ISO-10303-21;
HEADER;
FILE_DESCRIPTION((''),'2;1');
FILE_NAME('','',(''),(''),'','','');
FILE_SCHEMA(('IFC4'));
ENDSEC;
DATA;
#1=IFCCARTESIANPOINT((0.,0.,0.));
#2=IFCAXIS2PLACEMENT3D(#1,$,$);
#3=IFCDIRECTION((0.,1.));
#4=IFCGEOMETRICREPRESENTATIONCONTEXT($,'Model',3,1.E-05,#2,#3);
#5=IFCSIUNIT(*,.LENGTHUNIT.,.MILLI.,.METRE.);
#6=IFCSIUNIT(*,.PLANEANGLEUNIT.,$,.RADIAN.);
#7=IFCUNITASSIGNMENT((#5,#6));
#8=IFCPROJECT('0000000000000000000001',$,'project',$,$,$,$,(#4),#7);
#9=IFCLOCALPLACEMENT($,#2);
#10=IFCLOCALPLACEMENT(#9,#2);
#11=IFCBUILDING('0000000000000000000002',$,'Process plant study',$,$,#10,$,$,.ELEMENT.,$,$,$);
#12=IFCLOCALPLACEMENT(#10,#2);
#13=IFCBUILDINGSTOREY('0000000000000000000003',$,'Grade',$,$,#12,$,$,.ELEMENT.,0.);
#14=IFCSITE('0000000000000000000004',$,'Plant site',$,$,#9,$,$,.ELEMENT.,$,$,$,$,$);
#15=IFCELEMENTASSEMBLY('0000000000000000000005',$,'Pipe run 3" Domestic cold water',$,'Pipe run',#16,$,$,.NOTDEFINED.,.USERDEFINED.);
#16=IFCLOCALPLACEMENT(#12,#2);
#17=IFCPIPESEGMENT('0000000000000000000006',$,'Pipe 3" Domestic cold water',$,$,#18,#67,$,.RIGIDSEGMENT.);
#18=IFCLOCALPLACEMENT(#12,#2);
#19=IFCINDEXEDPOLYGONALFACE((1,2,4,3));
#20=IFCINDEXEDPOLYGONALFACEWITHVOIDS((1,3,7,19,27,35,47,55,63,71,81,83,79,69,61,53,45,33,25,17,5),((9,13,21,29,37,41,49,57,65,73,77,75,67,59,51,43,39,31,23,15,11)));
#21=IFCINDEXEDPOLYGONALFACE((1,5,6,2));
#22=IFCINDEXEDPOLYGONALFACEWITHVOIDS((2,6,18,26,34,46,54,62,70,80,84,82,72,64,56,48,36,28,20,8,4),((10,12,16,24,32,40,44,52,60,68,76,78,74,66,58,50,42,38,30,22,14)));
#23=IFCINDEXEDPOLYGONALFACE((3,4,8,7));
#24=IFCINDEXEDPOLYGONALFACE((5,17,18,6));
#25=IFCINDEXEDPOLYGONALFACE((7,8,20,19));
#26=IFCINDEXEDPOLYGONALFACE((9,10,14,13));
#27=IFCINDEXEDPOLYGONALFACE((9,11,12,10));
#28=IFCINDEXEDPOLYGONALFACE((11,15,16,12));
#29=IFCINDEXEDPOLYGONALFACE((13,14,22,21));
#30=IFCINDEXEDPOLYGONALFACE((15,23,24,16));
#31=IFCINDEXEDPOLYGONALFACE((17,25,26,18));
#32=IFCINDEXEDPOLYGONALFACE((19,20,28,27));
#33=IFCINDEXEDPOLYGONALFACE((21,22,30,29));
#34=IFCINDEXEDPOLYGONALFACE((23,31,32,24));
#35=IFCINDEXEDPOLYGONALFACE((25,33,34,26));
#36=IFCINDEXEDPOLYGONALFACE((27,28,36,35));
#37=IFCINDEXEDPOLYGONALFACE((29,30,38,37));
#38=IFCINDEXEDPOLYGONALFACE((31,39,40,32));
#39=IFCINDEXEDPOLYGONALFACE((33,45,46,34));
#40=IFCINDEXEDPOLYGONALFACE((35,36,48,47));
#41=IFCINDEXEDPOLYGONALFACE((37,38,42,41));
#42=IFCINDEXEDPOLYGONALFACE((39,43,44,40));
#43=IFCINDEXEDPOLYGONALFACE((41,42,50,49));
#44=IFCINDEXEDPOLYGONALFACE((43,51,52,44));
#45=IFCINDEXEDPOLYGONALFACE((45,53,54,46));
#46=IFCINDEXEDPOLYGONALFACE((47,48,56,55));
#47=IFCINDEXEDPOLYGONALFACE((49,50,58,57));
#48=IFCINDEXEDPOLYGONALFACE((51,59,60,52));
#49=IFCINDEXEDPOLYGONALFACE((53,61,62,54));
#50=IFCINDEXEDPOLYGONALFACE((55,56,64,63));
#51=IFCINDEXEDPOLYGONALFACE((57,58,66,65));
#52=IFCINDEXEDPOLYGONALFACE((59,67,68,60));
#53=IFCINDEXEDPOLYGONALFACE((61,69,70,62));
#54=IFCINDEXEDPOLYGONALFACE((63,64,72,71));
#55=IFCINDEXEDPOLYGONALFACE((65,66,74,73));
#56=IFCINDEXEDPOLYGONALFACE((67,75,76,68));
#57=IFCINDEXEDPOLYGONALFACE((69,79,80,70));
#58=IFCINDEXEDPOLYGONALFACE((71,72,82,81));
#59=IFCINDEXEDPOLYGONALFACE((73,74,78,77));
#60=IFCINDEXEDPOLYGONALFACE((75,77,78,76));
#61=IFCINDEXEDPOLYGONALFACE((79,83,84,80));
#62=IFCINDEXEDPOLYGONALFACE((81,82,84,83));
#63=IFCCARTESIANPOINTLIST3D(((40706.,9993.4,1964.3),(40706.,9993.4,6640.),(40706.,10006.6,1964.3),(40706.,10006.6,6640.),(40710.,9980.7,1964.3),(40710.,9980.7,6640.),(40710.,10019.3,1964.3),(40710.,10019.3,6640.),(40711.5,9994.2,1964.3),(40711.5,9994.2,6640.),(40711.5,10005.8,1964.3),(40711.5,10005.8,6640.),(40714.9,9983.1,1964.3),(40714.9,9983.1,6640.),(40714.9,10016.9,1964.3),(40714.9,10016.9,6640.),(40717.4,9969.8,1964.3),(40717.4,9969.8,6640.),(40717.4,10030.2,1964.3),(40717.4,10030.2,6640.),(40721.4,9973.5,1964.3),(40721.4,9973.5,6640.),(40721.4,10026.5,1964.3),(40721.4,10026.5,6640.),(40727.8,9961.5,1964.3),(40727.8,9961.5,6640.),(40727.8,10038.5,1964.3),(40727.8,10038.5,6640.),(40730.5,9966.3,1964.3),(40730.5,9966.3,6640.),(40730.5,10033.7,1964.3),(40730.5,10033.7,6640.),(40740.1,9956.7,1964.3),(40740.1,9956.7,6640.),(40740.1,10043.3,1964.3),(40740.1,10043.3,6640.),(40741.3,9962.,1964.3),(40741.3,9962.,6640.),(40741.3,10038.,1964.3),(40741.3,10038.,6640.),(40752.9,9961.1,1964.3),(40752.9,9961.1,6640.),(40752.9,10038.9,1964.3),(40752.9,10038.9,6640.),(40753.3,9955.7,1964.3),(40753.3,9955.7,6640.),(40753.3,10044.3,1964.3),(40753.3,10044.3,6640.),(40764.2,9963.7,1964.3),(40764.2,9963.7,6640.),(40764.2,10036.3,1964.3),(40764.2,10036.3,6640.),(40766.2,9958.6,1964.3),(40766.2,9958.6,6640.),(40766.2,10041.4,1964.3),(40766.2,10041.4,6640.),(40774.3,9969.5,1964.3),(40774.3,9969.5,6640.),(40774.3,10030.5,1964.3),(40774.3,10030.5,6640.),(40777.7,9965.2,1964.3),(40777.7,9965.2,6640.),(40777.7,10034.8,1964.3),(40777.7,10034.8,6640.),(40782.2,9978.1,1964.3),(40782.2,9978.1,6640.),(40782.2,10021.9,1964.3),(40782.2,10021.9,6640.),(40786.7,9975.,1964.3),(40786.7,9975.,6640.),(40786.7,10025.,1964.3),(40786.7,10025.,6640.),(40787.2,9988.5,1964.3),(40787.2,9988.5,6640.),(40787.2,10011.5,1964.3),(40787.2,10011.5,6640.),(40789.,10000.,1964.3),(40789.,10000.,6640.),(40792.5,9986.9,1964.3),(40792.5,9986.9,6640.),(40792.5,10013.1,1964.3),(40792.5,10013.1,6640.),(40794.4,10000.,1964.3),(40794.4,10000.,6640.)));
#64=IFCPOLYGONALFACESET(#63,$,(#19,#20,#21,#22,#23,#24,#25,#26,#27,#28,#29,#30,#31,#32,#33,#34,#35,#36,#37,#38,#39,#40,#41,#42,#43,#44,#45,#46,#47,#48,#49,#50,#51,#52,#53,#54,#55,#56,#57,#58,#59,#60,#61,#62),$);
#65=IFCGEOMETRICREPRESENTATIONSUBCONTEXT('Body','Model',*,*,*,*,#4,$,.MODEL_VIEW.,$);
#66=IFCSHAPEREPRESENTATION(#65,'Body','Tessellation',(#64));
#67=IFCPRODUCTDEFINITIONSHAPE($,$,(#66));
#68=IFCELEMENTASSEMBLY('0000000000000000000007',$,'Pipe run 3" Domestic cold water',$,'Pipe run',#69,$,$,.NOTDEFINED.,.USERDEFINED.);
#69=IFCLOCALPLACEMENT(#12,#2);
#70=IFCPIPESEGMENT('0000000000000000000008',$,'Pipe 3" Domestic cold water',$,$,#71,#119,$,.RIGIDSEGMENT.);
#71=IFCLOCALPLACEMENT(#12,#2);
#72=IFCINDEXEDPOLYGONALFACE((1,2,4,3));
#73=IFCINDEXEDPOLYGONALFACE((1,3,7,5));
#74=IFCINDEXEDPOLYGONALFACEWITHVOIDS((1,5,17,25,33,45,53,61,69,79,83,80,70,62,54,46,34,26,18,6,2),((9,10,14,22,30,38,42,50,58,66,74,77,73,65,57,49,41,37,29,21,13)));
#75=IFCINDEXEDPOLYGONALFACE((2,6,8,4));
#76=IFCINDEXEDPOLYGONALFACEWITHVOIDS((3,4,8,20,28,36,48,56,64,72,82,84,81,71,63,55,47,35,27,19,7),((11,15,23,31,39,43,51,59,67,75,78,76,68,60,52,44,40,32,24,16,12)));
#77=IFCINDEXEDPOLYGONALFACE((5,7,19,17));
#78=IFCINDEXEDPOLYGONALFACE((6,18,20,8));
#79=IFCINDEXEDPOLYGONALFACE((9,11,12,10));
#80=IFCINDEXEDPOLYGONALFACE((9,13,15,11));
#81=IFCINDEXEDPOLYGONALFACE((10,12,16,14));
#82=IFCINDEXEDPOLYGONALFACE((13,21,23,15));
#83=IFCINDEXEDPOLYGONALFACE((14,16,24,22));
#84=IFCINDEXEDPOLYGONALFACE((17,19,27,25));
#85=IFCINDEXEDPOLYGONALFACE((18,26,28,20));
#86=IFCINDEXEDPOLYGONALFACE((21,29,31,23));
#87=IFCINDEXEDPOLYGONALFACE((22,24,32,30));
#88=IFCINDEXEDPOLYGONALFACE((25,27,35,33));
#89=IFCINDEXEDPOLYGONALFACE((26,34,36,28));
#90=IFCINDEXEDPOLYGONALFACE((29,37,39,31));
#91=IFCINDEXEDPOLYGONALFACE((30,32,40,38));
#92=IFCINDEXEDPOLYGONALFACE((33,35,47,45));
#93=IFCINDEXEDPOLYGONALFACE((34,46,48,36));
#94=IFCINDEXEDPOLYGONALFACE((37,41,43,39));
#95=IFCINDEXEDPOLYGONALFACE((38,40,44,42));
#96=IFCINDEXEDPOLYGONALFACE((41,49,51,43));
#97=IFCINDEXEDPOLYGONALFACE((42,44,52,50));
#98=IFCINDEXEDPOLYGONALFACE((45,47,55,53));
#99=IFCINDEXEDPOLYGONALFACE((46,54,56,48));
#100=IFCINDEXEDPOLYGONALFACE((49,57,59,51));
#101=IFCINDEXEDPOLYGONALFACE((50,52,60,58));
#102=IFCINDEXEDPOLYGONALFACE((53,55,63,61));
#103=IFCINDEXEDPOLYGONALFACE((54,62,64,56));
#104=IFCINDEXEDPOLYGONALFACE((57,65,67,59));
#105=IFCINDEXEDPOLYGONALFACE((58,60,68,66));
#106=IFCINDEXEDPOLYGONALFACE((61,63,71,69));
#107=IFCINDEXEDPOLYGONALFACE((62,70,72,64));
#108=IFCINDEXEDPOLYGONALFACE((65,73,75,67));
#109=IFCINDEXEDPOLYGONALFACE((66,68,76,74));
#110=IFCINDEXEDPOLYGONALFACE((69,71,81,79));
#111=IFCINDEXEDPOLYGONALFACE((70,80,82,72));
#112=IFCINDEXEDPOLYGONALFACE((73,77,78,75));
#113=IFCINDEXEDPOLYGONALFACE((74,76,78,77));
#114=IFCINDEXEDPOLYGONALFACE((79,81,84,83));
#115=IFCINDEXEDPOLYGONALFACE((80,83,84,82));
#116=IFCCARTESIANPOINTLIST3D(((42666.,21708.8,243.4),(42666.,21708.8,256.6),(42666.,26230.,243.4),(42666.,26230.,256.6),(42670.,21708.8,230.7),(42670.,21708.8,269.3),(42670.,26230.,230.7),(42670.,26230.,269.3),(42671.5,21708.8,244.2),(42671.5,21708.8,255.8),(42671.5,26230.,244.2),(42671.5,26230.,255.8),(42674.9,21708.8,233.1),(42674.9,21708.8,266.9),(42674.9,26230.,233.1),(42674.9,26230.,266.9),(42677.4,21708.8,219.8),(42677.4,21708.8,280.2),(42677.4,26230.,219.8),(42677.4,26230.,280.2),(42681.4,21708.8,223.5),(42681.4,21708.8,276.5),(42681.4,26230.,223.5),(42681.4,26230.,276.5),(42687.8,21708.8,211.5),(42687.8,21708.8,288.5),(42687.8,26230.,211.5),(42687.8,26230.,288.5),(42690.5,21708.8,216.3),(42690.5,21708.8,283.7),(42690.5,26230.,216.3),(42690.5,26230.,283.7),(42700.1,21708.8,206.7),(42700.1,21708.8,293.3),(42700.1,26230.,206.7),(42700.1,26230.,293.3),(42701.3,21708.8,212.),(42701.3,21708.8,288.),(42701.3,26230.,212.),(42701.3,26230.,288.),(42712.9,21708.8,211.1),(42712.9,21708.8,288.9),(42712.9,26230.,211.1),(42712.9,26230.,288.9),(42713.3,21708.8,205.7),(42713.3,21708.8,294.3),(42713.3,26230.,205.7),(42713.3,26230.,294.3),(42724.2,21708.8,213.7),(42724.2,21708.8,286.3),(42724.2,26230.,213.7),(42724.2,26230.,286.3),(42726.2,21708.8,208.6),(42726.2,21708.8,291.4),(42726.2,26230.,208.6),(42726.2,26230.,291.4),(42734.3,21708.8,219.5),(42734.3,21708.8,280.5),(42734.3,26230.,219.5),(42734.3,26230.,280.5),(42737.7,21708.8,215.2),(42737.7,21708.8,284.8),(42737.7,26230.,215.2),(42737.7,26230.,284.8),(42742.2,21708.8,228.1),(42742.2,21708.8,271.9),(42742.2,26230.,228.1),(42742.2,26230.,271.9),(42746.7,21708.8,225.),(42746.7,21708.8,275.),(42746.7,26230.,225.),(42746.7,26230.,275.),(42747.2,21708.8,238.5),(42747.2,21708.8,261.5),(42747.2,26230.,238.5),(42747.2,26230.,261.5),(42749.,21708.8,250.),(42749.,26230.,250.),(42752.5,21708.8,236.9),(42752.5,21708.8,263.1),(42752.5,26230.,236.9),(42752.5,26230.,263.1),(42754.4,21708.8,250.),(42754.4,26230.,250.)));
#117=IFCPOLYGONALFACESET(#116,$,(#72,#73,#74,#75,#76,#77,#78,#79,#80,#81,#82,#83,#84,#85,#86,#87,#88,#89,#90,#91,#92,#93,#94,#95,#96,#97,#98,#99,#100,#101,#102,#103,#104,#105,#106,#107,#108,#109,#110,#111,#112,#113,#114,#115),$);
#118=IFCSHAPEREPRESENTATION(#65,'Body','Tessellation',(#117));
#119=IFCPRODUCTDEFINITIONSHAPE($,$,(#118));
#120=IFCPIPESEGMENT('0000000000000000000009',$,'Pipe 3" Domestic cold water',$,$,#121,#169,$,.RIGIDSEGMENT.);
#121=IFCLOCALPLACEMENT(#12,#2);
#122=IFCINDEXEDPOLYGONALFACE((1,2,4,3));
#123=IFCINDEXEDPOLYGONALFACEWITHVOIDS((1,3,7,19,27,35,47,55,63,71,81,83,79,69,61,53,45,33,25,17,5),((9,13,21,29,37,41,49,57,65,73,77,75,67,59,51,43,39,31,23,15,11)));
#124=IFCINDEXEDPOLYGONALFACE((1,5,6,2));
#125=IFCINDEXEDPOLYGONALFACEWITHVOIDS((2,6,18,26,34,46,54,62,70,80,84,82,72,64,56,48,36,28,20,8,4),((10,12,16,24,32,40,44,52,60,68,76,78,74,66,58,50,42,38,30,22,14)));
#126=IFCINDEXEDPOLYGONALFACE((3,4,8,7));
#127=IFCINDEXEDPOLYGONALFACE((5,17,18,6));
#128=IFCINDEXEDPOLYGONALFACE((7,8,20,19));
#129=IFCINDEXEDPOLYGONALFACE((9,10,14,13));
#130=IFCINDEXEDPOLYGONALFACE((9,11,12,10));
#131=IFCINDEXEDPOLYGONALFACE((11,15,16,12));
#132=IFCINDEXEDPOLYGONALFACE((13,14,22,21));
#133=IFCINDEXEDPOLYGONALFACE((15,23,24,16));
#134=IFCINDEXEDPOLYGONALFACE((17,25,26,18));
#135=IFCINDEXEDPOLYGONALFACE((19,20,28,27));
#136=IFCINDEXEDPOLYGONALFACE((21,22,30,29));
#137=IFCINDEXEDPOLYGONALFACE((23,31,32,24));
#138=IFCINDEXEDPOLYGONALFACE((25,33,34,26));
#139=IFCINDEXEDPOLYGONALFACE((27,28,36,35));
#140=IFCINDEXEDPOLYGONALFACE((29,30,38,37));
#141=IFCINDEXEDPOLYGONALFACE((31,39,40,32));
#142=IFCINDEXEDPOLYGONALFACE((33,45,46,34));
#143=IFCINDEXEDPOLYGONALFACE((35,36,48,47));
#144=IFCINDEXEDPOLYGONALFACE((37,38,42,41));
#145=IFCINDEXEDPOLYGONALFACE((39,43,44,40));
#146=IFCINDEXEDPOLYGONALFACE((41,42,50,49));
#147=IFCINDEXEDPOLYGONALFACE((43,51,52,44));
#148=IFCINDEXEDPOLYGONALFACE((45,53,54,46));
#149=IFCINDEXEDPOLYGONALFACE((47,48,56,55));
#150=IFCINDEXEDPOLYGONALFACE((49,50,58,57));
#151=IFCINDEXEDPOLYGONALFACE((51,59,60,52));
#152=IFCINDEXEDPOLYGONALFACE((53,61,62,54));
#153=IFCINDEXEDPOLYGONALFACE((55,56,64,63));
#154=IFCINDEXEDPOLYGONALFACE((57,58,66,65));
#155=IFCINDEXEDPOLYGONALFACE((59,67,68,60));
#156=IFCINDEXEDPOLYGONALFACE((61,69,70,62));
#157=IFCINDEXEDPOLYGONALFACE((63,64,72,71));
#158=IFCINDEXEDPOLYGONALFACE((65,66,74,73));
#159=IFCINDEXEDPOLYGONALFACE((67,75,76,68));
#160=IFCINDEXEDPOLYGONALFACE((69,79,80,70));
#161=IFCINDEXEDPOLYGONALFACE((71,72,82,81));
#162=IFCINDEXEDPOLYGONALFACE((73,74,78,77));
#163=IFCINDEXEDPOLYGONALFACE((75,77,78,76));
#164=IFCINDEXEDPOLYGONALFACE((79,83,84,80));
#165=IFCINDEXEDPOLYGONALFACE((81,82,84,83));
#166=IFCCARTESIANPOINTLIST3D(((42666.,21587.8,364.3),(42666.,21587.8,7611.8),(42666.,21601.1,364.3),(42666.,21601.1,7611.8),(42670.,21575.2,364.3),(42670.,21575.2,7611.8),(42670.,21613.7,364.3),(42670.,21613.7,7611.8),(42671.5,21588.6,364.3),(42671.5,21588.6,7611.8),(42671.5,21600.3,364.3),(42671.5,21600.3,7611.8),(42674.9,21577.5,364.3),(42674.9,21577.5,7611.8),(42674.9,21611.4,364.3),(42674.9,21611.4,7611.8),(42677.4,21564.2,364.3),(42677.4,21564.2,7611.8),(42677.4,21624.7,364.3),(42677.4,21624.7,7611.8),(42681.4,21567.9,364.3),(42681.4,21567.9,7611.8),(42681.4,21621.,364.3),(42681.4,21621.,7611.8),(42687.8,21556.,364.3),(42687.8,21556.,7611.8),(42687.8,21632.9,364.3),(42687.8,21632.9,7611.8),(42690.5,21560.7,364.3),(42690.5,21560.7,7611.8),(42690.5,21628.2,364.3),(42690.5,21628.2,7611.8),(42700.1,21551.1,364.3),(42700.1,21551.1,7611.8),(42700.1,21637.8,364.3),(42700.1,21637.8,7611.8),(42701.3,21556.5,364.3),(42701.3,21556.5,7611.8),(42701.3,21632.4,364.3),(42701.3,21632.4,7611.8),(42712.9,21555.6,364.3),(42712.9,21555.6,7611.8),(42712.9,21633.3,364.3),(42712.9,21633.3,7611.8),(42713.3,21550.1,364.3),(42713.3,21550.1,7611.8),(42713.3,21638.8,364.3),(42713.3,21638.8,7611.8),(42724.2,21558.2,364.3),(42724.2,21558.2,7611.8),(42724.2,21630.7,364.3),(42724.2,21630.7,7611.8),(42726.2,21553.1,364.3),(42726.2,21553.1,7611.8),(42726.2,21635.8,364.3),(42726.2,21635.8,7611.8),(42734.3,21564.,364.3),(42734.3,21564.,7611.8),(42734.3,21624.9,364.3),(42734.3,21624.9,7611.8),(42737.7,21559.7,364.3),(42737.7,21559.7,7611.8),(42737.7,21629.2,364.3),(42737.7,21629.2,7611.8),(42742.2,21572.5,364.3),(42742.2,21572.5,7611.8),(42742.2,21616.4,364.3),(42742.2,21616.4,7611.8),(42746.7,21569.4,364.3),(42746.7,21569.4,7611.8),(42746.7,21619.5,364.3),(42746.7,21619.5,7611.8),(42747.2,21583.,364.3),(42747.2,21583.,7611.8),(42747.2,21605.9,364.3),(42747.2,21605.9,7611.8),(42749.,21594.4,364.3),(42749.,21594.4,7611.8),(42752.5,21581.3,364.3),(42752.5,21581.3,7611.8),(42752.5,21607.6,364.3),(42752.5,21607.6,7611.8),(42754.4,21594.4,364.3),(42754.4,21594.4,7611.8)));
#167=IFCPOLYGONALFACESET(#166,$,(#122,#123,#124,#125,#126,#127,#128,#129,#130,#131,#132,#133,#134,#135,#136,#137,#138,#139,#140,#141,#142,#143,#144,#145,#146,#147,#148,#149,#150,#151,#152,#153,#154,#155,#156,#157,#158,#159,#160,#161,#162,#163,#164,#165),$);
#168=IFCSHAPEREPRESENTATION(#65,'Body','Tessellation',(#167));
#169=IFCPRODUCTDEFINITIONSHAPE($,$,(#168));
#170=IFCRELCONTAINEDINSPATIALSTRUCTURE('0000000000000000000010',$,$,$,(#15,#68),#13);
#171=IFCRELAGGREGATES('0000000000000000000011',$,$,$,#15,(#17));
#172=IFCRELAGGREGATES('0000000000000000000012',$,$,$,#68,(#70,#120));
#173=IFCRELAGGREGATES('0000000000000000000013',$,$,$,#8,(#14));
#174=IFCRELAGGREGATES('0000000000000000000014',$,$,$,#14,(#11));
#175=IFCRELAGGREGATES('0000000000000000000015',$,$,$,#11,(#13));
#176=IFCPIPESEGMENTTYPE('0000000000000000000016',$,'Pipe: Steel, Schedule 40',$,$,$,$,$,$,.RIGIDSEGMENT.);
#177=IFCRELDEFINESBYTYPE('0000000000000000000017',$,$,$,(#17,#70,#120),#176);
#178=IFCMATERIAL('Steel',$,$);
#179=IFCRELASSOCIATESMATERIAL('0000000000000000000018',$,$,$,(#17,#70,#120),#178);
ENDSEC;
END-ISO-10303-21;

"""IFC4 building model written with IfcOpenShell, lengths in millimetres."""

from ifc_helpers import new_model, si_unit, direction, frame, origin, origin_with_axes, origin_2d, place, context, subcontext, project, spatial, hollow_circle, extrude, material, type_object, element, aggregate, save


model = new_model("IFC4")

# Units and contexts
model_context = context("Model", 3, precision=1e-05, world=origin(), true_north=direction((0.0, 1.0)))
body_context = subcontext(model_context, "Body", "Model", "MODEL_VIEW")
ifc_project = project(units=[si_unit("LENGTHUNIT", "METRE", prefix="MILLI"), si_unit("PLANEANGLEUNIT", "RADIAN")], contexts=[model_context])

# Site, building, storey
site_placement = place(None, origin())
site = spatial("IfcSite", under=ifc_project, at=site_placement, Name="Plant site", CompositionType="ELEMENT")
building_placement = place(site_placement, origin())
building = spatial("IfcBuilding", under=site, at=building_placement, Name="Process plant study", CompositionType="ELEMENT")
storey_placement = place(building_placement, origin())
storey = spatial("IfcBuildingStorey", under=building, at=storey_placement, Name="Grade", CompositionType="ELEMENT", Elevation=0.0)

# Shared definitions
ifc_material = material(Name="Steel")
pipe_segment_type = type_object("IfcPipeSegmentType", Name="Pipe: Steel, Schedule 40", PredefinedType="RIGIDSEGMENT")

# Element assemblies, pipe segments
assembly_1_placement = place(storey_placement, origin_with_axes())
assembly_1 = element("IfcElementAssembly", 1, at=assembly_1_placement, inside=storey, Name="Pipe run 3\" Domestic cold water", ObjectType="Pipe run", AssemblyPlace="NOTDEFINED", PredefinedType="USERDEFINED")
pipe_segment_1_placement = place(storey_placement, origin_with_axes())
pipe_segment_1 = element("IfcPipeSegment", 2, at=pipe_segment_1_placement, type_object=pipe_segment_type, material=ifc_material, Name="Pipe 3\" Domestic cold water", PredefinedType="RIGIDSEGMENT", context=body_context, shape_type="SweptSolid", body=[
    extrude(hollow_circle(Radius=44.5, WallThickness=5.5, at=origin_2d()), frame((40750.0, 10000.0, 1964.3), z_axis=(0.0, 0.0, 1.0), x_axis=(1.0, 0.0, 0.0)), (0.0, 0.0, 1.0), 4675.7),
])
assembly_2_placement = place(storey_placement, origin_with_axes())
assembly_2 = element("IfcElementAssembly", 3, at=assembly_2_placement, inside=storey, Name="Pipe run 3\" Domestic cold water", ObjectType="Pipe run", AssemblyPlace="NOTDEFINED", PredefinedType="USERDEFINED")
pipe_segment_2_placement = place(storey_placement, origin_with_axes())
pipe_segment_2 = element("IfcPipeSegment", 4, at=pipe_segment_2_placement, type_object=pipe_segment_type, material=ifc_material, Name="Pipe 3\" Domestic cold water", PredefinedType="RIGIDSEGMENT", context=body_context, shape_type="SweptSolid", body=[
    extrude(hollow_circle(Radius=44.5, WallThickness=5.5, at=origin_2d()), frame((42710.0, 26230.0, 250.0), z_axis=(0.0, -1.0, 0.0), x_axis=(1.0, 0.0, 0.0)), (0.0, 0.0, 1.0), 4521.2),
])
pipe_segment_3_placement = place(storey_placement, origin_with_axes())
pipe_segment_3 = element("IfcPipeSegment", 5, at=pipe_segment_3_placement, type_object=pipe_segment_type, material=ifc_material, Name="Pipe 3\" Domestic cold water", PredefinedType="RIGIDSEGMENT", context=body_context, shape_type="SweptSolid", body=[
    extrude(hollow_circle(Radius=44.5, WallThickness=5.5, at=origin_2d()), frame((42710.0, 21594.5, 364.3), z_axis=(0.0, 0.0, 1.0), x_axis=(1.0, 0.0, 0.0)), (0.0, 0.0, 1.0), 7247.5),
])

aggregate(assembly_1, [pipe_segment_1])
aggregate(assembly_2, [pipe_segment_2, pipe_segment_3])

save(model, "model.ifc")
